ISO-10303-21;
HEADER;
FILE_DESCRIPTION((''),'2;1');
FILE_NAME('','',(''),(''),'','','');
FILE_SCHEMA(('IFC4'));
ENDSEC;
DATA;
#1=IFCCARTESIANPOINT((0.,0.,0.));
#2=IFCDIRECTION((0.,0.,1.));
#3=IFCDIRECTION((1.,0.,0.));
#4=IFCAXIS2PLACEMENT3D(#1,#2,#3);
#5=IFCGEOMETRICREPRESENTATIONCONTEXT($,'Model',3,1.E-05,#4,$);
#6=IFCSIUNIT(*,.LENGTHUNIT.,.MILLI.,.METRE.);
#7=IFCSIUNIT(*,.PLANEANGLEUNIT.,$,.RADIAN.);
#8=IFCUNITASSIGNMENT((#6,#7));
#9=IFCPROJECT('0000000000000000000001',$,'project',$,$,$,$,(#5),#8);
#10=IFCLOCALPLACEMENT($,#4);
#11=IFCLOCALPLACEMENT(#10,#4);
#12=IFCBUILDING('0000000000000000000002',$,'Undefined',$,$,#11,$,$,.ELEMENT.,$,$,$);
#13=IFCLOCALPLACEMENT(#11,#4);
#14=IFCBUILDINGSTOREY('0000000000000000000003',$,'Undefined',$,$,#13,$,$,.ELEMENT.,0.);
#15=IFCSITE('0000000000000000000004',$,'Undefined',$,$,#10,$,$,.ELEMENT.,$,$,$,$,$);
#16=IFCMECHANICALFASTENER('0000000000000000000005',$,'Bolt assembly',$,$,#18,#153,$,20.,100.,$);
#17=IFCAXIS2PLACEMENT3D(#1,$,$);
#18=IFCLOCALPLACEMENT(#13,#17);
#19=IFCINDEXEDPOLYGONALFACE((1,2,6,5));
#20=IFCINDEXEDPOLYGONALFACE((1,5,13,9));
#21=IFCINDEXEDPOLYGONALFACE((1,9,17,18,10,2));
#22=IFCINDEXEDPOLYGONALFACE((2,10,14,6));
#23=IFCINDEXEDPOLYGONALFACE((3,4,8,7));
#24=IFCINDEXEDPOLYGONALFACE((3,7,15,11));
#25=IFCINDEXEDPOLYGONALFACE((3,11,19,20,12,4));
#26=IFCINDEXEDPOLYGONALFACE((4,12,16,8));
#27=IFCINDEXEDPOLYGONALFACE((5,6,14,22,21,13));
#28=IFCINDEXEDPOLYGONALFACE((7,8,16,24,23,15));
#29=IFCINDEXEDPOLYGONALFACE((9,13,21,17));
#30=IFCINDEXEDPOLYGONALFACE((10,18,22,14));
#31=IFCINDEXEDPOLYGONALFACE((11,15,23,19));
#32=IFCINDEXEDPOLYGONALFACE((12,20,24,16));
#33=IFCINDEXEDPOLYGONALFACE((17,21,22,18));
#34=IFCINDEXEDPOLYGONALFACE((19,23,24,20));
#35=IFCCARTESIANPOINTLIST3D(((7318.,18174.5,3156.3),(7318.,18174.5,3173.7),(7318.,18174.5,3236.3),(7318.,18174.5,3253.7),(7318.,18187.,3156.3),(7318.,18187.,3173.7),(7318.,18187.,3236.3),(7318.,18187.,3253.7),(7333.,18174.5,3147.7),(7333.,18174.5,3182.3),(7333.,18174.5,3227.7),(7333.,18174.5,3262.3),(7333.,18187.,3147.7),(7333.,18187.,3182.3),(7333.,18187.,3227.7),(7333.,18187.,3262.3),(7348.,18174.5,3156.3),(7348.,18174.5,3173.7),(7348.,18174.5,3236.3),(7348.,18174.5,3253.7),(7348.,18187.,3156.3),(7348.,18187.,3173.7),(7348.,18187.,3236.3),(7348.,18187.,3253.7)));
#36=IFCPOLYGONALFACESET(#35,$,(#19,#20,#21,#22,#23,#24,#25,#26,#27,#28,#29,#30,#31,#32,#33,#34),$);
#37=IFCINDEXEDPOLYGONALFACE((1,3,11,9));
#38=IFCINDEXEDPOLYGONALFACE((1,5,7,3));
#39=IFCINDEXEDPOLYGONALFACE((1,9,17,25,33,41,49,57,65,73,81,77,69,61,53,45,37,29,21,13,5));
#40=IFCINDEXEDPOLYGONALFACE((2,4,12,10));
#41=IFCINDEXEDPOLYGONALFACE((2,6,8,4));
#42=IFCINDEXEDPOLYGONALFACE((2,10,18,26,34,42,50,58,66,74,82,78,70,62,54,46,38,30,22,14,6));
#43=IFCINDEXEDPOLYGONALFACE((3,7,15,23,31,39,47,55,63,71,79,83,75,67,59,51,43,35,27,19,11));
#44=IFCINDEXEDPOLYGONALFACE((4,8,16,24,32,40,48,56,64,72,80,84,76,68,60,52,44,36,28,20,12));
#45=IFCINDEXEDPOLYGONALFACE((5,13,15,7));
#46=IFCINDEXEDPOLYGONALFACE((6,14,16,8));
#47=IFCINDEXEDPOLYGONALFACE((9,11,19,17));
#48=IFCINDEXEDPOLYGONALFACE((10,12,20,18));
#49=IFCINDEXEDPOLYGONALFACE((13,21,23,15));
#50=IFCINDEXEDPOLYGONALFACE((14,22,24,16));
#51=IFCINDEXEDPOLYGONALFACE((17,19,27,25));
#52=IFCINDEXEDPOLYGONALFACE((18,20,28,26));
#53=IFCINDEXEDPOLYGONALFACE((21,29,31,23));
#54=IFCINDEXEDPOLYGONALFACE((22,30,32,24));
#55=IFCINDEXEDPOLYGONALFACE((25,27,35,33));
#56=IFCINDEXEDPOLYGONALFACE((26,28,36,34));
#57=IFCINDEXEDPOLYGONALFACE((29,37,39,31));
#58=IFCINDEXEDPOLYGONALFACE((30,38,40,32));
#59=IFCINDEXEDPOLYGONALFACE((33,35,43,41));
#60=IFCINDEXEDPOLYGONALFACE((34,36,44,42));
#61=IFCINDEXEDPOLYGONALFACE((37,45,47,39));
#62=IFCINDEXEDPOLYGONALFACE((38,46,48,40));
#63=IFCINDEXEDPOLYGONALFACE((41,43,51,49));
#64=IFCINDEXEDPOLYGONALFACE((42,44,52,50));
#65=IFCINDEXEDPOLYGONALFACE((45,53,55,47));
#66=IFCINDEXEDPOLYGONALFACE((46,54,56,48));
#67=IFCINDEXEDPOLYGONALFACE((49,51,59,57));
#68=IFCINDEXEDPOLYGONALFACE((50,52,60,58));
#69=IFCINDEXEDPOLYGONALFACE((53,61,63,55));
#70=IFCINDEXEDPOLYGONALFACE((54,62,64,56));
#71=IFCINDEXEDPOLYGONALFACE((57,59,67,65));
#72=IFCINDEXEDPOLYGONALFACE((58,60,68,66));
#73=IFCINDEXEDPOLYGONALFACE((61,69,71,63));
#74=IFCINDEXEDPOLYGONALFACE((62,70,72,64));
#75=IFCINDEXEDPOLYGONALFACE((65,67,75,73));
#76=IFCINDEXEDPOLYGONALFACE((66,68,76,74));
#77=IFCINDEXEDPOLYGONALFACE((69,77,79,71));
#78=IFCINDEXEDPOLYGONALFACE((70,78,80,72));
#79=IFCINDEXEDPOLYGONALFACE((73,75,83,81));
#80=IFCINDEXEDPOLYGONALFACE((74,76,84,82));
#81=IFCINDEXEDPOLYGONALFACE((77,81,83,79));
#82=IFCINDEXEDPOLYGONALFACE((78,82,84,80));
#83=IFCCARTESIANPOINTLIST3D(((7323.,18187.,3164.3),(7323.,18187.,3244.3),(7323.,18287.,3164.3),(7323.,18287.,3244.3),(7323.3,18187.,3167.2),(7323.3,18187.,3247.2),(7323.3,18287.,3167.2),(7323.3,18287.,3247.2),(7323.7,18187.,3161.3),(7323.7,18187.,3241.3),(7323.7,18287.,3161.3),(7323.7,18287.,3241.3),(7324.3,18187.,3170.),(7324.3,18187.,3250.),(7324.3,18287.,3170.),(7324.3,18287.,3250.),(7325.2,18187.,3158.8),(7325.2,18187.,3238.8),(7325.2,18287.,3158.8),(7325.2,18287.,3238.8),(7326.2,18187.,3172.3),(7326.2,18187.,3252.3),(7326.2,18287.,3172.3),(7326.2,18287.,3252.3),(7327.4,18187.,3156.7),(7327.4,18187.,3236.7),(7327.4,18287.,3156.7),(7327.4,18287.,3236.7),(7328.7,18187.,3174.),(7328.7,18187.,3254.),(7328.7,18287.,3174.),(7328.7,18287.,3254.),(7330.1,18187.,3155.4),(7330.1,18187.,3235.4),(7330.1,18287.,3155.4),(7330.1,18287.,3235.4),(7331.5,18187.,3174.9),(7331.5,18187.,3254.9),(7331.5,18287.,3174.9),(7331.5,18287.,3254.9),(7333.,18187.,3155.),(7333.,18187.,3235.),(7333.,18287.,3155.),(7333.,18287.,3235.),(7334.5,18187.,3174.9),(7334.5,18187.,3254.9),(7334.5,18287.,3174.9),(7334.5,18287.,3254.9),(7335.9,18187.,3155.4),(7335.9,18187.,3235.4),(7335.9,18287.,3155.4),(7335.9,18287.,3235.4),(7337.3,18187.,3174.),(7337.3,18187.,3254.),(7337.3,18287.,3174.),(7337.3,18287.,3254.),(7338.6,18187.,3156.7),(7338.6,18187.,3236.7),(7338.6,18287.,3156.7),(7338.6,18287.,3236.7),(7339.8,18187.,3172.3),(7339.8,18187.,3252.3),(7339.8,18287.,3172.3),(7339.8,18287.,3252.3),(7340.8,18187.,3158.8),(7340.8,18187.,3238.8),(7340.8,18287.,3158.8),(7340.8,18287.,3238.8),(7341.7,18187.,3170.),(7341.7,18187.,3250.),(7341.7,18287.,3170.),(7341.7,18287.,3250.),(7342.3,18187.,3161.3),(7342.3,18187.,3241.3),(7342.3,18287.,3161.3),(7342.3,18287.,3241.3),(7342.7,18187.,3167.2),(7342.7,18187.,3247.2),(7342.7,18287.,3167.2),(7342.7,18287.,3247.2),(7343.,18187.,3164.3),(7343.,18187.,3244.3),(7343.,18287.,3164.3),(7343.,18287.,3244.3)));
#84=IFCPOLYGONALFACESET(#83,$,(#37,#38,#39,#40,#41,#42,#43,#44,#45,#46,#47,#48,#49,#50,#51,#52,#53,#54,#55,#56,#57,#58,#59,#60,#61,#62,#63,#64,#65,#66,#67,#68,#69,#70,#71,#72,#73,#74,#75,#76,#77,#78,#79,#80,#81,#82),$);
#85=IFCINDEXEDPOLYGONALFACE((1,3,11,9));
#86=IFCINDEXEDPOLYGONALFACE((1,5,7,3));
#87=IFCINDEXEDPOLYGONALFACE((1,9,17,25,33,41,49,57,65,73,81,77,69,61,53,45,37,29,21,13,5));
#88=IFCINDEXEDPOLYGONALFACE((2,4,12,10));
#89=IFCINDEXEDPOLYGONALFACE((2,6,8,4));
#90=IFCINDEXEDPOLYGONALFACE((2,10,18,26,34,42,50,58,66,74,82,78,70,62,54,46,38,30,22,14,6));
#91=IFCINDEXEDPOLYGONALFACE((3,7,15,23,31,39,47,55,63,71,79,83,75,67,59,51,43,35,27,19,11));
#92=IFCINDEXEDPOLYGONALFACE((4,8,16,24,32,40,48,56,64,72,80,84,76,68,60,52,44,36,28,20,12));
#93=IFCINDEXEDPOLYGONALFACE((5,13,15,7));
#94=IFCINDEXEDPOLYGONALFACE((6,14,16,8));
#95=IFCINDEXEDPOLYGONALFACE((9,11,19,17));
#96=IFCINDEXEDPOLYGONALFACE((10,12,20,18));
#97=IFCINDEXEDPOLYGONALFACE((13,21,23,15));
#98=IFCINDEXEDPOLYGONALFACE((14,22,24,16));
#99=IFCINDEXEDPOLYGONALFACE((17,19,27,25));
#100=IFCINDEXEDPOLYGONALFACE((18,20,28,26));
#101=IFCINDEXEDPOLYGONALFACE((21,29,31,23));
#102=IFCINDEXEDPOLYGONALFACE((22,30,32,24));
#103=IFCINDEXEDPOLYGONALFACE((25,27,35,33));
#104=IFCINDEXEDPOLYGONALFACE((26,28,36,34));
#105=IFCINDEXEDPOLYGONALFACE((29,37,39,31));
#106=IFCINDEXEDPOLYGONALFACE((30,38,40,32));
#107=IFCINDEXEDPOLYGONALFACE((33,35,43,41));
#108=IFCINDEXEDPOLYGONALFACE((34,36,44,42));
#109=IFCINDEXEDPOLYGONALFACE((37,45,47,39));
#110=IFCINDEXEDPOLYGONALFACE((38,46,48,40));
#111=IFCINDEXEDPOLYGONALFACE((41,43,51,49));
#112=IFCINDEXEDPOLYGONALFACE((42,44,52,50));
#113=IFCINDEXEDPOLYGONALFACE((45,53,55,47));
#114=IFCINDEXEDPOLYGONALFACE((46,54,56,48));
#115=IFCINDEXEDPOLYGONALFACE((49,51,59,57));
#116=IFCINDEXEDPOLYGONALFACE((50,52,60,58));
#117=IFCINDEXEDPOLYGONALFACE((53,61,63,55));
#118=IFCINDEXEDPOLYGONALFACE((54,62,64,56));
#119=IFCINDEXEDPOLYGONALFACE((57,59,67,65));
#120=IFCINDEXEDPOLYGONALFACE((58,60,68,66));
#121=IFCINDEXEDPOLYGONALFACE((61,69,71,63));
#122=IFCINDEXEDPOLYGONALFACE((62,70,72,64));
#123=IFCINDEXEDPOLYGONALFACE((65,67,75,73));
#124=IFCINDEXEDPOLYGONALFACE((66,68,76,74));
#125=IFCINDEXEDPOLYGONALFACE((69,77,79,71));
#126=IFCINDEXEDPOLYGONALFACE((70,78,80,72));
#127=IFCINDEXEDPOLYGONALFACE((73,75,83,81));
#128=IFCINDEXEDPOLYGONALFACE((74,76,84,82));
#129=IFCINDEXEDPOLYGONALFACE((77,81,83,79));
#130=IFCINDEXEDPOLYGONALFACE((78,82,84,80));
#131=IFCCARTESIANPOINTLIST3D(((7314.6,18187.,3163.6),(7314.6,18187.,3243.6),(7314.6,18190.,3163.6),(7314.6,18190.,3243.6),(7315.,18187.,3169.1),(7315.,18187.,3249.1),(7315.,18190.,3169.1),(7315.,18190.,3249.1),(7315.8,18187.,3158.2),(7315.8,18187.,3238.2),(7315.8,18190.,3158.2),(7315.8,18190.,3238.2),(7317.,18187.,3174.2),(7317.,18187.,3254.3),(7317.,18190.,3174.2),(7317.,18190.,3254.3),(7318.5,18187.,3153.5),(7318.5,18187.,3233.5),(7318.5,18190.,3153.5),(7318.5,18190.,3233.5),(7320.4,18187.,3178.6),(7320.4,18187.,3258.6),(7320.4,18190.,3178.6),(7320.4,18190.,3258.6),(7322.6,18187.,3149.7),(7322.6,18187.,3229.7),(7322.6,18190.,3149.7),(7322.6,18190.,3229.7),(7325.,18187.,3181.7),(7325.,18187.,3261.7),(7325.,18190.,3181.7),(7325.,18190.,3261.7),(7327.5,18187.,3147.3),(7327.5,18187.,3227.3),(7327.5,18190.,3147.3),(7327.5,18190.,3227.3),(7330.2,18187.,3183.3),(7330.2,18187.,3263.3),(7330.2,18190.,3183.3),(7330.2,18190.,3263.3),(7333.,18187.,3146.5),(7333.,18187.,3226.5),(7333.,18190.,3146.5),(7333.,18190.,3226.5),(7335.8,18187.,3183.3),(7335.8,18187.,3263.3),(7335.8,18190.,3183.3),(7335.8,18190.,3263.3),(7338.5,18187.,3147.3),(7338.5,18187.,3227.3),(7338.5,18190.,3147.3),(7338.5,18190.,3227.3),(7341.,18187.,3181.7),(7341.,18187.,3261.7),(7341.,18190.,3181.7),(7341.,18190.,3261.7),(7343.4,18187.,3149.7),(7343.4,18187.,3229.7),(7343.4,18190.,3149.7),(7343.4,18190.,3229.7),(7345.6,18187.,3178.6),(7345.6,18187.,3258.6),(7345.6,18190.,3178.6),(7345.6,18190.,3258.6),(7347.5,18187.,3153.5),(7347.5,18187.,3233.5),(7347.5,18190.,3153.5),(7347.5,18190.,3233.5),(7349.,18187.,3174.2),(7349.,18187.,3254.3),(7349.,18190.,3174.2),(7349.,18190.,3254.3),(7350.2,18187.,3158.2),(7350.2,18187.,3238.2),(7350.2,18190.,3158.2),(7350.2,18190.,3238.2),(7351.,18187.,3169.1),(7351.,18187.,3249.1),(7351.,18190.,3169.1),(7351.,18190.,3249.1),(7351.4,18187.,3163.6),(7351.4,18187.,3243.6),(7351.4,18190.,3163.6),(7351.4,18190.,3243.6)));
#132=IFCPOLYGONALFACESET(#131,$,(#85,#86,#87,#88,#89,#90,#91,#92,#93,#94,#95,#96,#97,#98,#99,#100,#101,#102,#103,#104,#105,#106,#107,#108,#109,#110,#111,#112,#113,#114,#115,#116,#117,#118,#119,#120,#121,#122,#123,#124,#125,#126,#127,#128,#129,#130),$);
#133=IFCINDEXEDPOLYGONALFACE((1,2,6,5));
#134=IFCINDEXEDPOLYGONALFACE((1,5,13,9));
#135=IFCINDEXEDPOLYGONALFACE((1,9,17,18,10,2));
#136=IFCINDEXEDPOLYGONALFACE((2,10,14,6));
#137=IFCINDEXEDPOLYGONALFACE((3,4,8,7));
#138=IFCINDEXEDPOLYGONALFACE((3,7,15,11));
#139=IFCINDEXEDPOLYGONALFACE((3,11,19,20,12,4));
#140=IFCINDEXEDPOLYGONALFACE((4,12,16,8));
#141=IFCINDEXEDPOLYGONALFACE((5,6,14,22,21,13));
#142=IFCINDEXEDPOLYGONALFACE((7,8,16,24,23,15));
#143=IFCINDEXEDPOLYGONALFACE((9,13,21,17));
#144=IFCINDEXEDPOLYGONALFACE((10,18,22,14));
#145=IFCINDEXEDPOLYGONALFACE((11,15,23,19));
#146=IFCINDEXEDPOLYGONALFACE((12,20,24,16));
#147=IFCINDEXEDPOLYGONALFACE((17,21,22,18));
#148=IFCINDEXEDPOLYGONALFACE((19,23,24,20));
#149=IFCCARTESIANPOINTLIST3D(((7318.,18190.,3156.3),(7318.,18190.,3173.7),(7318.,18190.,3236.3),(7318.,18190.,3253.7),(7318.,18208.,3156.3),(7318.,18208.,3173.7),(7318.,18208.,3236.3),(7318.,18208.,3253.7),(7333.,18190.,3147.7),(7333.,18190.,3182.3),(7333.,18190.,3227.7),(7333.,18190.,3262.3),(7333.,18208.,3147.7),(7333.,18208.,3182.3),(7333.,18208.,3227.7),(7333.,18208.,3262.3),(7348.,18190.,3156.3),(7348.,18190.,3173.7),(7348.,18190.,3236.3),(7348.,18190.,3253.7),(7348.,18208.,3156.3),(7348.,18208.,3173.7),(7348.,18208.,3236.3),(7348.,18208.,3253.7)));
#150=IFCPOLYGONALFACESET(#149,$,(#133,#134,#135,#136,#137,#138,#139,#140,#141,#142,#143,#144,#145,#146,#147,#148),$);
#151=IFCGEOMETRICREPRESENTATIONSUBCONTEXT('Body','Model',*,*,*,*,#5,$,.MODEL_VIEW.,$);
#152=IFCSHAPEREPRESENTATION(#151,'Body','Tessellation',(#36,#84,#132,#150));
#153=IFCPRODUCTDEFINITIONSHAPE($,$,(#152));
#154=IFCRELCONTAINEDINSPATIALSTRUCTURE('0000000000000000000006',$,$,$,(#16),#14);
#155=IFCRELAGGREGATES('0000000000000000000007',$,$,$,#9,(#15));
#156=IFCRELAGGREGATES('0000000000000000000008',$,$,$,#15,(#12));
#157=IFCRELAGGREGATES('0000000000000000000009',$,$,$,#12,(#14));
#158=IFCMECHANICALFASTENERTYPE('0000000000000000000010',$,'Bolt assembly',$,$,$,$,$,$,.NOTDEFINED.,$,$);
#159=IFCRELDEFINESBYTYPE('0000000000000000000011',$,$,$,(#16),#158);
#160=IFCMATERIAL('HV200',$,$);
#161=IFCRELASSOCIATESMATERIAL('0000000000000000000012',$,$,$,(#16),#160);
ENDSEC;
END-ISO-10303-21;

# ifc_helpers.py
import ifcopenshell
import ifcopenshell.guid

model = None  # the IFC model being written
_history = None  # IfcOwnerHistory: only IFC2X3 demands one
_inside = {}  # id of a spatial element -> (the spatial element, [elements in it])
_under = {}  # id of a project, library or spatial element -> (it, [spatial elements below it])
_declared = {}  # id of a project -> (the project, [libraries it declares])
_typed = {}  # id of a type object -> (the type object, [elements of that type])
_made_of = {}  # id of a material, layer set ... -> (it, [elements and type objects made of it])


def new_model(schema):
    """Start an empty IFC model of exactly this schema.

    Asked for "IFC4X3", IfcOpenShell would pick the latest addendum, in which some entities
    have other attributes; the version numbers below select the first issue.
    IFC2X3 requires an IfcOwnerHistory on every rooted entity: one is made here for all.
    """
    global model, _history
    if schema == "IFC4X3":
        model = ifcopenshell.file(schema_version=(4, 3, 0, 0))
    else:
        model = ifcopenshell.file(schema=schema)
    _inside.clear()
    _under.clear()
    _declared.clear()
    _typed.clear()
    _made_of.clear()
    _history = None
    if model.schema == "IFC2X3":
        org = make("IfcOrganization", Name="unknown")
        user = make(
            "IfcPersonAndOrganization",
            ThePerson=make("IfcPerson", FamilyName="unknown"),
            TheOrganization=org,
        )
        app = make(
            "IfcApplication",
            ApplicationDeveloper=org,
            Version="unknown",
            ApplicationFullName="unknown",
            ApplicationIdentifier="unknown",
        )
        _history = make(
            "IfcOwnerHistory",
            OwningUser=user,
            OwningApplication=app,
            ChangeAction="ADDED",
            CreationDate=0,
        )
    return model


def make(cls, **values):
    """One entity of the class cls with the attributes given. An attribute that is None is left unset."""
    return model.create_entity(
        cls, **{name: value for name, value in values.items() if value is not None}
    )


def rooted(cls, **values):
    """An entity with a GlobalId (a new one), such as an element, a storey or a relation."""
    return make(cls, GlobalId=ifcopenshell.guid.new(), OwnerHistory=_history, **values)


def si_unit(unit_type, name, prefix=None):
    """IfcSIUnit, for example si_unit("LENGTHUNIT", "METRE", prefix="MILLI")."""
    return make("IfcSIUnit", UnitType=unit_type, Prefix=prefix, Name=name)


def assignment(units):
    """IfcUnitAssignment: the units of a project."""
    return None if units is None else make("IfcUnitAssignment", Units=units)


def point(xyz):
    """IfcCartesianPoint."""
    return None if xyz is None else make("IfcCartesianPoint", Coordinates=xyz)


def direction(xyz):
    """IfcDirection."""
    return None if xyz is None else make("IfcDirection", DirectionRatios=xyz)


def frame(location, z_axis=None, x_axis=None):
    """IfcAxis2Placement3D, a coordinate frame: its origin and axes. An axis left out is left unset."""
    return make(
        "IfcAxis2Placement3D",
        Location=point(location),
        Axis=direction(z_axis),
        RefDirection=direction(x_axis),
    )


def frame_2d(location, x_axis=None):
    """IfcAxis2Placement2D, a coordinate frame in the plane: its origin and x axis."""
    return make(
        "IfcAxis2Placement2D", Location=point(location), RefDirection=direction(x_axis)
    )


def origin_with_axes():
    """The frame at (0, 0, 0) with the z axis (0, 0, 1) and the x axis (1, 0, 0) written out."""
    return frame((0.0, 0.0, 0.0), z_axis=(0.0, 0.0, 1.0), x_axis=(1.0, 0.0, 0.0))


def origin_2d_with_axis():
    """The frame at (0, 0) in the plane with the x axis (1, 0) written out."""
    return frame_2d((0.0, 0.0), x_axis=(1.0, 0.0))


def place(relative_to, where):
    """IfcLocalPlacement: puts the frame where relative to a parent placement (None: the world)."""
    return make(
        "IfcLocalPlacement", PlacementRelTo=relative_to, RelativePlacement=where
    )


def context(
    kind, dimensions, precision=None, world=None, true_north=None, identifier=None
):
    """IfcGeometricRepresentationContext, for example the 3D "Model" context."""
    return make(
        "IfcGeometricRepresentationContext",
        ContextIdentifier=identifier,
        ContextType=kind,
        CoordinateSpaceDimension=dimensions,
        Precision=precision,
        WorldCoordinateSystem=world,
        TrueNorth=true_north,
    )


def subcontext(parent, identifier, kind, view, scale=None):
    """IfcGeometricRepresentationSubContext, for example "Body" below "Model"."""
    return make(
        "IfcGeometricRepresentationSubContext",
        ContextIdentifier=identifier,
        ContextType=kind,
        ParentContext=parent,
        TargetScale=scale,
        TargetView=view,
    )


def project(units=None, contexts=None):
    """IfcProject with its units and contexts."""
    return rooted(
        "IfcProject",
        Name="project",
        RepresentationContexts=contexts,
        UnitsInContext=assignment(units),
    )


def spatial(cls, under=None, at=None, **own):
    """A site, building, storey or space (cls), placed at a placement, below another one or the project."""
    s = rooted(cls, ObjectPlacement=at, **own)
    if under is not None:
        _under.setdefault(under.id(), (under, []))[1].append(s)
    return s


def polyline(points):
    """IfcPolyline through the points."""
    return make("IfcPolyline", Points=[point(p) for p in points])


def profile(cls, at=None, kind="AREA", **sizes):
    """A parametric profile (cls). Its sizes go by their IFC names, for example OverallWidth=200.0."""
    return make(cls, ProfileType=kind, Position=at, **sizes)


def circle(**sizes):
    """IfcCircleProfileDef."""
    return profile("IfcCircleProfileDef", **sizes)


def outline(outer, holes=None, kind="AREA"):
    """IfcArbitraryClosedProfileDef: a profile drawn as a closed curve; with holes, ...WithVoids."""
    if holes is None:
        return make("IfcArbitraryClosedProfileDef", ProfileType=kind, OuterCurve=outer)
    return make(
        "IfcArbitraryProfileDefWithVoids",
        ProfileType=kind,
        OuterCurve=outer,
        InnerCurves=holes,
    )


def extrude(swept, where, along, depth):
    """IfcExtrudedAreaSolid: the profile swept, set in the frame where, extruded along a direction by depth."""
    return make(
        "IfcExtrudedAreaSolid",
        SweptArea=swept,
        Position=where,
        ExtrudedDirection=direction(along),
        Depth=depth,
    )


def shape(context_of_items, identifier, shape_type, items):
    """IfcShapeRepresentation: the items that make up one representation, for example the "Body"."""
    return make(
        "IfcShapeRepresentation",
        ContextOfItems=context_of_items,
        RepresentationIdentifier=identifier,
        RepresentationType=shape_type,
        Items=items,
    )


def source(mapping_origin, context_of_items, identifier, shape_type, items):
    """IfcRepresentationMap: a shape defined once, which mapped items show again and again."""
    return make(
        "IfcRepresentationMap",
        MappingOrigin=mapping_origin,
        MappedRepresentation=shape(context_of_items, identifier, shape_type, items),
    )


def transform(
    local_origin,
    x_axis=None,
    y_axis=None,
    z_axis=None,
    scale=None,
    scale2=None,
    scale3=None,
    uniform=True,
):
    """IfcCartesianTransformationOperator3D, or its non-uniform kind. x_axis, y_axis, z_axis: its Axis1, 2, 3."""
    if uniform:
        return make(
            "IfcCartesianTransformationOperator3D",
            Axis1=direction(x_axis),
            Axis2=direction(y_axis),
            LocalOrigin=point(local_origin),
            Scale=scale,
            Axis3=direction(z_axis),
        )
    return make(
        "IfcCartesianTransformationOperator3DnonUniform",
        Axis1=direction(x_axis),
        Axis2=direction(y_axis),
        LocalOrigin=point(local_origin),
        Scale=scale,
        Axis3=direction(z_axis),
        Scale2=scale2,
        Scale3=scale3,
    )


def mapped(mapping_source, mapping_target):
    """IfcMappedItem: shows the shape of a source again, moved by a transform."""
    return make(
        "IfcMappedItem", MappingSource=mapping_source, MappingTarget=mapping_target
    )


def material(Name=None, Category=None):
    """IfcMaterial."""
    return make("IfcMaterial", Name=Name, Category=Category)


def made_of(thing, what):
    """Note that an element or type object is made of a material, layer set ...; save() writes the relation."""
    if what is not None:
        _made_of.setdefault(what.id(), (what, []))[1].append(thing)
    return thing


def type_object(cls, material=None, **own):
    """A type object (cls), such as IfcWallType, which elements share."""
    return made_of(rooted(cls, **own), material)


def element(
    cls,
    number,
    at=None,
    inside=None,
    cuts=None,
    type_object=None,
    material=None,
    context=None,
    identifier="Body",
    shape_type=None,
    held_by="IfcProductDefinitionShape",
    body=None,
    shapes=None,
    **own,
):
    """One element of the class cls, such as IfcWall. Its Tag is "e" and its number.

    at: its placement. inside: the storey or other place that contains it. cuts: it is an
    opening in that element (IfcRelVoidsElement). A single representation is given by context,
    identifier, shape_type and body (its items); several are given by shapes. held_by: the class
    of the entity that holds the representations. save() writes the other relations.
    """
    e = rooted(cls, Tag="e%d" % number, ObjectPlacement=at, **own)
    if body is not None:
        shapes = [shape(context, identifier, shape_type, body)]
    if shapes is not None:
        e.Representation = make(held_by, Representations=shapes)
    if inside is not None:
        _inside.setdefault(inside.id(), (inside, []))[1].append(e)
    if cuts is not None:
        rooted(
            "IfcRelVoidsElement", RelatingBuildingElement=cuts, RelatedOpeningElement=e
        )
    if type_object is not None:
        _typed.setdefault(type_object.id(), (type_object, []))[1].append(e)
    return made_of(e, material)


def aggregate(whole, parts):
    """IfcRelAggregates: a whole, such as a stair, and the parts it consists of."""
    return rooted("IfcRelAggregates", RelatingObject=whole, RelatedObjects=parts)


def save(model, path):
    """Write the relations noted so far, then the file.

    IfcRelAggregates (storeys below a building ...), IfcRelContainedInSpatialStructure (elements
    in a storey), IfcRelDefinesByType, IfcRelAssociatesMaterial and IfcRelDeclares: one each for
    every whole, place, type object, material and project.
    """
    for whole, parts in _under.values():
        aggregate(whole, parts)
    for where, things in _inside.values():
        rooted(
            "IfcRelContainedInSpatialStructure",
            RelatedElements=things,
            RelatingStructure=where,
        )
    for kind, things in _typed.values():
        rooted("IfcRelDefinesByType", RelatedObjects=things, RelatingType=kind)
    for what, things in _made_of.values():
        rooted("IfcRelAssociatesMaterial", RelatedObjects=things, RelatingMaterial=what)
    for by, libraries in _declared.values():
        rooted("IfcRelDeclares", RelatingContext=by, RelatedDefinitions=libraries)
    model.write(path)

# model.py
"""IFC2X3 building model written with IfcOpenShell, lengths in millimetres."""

from ifc_helpers import new_model, si_unit, frame, origin_with_axes, origin_2d_with_axis, place, context, subcontext, project, spatial, polyline, circle, outline, extrude, source, transform, mapped, material, type_object, element, save


model = new_model("IFC2X3")

# Units and contexts
model_context = context("Model", 3, precision=1e-05, world=origin_with_axes())
body_context = subcontext(model_context, "Body", "Model", "MODEL_VIEW")
ifc_project = project(units=[si_unit("LENGTHUNIT", "METRE", prefix="MILLI"), si_unit("PLANEANGLEUNIT", "RADIAN")], contexts=[model_context])

# Site, building, storey
site_placement = place(None, origin_with_axes())
site = spatial("IfcSite", under=ifc_project, at=site_placement, Name="Undefined", CompositionType="ELEMENT")
building_placement = place(site_placement, origin_with_axes())
building = spatial("IfcBuilding", under=site, at=building_placement, Name="Undefined", CompositionType="ELEMENT")
storey_placement = place(building_placement, origin_with_axes())
storey = spatial("IfcBuildingStorey", under=building, at=storey_placement, Name="Undefined", CompositionType="ELEMENT", Elevation=0.0)

# Mechanical fastener
ifc_material_1 = material(Name="HV200")
mechanical_fastener_type = type_object("IfcMechanicalFastenerType", Name="Bolt assembly")
shared_shape_1 = source(origin_with_axes(), body_context, "Body", "SweptSolid", [
    extrude(outline(polyline([(17.3, 0.0), (8.7, 15.0), (-8.7, 15.0), (-17.3, 0.0), (-8.7, -15.0), (8.7, -15.0), (17.3, 0.0)])), frame((0.0, -12.5, 0.0), z_axis=(0.0, 1.0, 0.0), x_axis=(1.0, 0.0, 0.0)), (0.0, 0.0, 1.0), 12.5),
    extrude(circle(Radius=10.0, at=origin_2d_with_axis()), frame((0.0, 0.0, 0.0), z_axis=(0.0, 1.0, 0.0), x_axis=(1.0, 0.0, 0.0)), (0.0, 0.0, 1.0), 100.0),
    extrude(circle(Radius=18.5, at=origin_2d_with_axis()), frame((0.0, 0.0, 0.0), z_axis=(0.0, 1.0, 0.0), x_axis=(1.0, 0.0, 0.0)), (0.0, 0.0, 1.0), 3.0),
    extrude(outline(polyline([(17.3, 0.0), (8.7, 15.0), (-8.7, 15.0), (-17.3, 0.0), (-8.7, -15.0), (8.7, -15.0), (17.3, 0.0)])), frame((0.0, 3.0, 0.0), z_axis=(0.0, 1.0, 0.0), x_axis=(1.0, 0.0, 0.0)), (0.0, 0.0, 1.0), 18.0),
])
for number, where, z_axis, x_axis, name in (
    (1, (7333.0, 18187.0, 3245.0), (1.0, 0.0, 0.0), (0.0, 0.0, -1.0), "Bolt assembly"),
):
    element("IfcMechanicalFastener", number, at=place(storey_placement, frame(where, z_axis=z_axis, x_axis=x_axis)), inside=storey, type_object=mechanical_fastener_type, material=ifc_material_1, Name=name, NominalDiameter=20.0, NominalLength=100.0, context=body_context, shape_type="MappedRepresentation", body=[
        mapped(shared_shape_1, transform((0.0, 0.0, 0.0))),
        mapped(shared_shape_1, transform((80.0, 0.0, 0.0))),
    ])

save(model, "model.ifc")
